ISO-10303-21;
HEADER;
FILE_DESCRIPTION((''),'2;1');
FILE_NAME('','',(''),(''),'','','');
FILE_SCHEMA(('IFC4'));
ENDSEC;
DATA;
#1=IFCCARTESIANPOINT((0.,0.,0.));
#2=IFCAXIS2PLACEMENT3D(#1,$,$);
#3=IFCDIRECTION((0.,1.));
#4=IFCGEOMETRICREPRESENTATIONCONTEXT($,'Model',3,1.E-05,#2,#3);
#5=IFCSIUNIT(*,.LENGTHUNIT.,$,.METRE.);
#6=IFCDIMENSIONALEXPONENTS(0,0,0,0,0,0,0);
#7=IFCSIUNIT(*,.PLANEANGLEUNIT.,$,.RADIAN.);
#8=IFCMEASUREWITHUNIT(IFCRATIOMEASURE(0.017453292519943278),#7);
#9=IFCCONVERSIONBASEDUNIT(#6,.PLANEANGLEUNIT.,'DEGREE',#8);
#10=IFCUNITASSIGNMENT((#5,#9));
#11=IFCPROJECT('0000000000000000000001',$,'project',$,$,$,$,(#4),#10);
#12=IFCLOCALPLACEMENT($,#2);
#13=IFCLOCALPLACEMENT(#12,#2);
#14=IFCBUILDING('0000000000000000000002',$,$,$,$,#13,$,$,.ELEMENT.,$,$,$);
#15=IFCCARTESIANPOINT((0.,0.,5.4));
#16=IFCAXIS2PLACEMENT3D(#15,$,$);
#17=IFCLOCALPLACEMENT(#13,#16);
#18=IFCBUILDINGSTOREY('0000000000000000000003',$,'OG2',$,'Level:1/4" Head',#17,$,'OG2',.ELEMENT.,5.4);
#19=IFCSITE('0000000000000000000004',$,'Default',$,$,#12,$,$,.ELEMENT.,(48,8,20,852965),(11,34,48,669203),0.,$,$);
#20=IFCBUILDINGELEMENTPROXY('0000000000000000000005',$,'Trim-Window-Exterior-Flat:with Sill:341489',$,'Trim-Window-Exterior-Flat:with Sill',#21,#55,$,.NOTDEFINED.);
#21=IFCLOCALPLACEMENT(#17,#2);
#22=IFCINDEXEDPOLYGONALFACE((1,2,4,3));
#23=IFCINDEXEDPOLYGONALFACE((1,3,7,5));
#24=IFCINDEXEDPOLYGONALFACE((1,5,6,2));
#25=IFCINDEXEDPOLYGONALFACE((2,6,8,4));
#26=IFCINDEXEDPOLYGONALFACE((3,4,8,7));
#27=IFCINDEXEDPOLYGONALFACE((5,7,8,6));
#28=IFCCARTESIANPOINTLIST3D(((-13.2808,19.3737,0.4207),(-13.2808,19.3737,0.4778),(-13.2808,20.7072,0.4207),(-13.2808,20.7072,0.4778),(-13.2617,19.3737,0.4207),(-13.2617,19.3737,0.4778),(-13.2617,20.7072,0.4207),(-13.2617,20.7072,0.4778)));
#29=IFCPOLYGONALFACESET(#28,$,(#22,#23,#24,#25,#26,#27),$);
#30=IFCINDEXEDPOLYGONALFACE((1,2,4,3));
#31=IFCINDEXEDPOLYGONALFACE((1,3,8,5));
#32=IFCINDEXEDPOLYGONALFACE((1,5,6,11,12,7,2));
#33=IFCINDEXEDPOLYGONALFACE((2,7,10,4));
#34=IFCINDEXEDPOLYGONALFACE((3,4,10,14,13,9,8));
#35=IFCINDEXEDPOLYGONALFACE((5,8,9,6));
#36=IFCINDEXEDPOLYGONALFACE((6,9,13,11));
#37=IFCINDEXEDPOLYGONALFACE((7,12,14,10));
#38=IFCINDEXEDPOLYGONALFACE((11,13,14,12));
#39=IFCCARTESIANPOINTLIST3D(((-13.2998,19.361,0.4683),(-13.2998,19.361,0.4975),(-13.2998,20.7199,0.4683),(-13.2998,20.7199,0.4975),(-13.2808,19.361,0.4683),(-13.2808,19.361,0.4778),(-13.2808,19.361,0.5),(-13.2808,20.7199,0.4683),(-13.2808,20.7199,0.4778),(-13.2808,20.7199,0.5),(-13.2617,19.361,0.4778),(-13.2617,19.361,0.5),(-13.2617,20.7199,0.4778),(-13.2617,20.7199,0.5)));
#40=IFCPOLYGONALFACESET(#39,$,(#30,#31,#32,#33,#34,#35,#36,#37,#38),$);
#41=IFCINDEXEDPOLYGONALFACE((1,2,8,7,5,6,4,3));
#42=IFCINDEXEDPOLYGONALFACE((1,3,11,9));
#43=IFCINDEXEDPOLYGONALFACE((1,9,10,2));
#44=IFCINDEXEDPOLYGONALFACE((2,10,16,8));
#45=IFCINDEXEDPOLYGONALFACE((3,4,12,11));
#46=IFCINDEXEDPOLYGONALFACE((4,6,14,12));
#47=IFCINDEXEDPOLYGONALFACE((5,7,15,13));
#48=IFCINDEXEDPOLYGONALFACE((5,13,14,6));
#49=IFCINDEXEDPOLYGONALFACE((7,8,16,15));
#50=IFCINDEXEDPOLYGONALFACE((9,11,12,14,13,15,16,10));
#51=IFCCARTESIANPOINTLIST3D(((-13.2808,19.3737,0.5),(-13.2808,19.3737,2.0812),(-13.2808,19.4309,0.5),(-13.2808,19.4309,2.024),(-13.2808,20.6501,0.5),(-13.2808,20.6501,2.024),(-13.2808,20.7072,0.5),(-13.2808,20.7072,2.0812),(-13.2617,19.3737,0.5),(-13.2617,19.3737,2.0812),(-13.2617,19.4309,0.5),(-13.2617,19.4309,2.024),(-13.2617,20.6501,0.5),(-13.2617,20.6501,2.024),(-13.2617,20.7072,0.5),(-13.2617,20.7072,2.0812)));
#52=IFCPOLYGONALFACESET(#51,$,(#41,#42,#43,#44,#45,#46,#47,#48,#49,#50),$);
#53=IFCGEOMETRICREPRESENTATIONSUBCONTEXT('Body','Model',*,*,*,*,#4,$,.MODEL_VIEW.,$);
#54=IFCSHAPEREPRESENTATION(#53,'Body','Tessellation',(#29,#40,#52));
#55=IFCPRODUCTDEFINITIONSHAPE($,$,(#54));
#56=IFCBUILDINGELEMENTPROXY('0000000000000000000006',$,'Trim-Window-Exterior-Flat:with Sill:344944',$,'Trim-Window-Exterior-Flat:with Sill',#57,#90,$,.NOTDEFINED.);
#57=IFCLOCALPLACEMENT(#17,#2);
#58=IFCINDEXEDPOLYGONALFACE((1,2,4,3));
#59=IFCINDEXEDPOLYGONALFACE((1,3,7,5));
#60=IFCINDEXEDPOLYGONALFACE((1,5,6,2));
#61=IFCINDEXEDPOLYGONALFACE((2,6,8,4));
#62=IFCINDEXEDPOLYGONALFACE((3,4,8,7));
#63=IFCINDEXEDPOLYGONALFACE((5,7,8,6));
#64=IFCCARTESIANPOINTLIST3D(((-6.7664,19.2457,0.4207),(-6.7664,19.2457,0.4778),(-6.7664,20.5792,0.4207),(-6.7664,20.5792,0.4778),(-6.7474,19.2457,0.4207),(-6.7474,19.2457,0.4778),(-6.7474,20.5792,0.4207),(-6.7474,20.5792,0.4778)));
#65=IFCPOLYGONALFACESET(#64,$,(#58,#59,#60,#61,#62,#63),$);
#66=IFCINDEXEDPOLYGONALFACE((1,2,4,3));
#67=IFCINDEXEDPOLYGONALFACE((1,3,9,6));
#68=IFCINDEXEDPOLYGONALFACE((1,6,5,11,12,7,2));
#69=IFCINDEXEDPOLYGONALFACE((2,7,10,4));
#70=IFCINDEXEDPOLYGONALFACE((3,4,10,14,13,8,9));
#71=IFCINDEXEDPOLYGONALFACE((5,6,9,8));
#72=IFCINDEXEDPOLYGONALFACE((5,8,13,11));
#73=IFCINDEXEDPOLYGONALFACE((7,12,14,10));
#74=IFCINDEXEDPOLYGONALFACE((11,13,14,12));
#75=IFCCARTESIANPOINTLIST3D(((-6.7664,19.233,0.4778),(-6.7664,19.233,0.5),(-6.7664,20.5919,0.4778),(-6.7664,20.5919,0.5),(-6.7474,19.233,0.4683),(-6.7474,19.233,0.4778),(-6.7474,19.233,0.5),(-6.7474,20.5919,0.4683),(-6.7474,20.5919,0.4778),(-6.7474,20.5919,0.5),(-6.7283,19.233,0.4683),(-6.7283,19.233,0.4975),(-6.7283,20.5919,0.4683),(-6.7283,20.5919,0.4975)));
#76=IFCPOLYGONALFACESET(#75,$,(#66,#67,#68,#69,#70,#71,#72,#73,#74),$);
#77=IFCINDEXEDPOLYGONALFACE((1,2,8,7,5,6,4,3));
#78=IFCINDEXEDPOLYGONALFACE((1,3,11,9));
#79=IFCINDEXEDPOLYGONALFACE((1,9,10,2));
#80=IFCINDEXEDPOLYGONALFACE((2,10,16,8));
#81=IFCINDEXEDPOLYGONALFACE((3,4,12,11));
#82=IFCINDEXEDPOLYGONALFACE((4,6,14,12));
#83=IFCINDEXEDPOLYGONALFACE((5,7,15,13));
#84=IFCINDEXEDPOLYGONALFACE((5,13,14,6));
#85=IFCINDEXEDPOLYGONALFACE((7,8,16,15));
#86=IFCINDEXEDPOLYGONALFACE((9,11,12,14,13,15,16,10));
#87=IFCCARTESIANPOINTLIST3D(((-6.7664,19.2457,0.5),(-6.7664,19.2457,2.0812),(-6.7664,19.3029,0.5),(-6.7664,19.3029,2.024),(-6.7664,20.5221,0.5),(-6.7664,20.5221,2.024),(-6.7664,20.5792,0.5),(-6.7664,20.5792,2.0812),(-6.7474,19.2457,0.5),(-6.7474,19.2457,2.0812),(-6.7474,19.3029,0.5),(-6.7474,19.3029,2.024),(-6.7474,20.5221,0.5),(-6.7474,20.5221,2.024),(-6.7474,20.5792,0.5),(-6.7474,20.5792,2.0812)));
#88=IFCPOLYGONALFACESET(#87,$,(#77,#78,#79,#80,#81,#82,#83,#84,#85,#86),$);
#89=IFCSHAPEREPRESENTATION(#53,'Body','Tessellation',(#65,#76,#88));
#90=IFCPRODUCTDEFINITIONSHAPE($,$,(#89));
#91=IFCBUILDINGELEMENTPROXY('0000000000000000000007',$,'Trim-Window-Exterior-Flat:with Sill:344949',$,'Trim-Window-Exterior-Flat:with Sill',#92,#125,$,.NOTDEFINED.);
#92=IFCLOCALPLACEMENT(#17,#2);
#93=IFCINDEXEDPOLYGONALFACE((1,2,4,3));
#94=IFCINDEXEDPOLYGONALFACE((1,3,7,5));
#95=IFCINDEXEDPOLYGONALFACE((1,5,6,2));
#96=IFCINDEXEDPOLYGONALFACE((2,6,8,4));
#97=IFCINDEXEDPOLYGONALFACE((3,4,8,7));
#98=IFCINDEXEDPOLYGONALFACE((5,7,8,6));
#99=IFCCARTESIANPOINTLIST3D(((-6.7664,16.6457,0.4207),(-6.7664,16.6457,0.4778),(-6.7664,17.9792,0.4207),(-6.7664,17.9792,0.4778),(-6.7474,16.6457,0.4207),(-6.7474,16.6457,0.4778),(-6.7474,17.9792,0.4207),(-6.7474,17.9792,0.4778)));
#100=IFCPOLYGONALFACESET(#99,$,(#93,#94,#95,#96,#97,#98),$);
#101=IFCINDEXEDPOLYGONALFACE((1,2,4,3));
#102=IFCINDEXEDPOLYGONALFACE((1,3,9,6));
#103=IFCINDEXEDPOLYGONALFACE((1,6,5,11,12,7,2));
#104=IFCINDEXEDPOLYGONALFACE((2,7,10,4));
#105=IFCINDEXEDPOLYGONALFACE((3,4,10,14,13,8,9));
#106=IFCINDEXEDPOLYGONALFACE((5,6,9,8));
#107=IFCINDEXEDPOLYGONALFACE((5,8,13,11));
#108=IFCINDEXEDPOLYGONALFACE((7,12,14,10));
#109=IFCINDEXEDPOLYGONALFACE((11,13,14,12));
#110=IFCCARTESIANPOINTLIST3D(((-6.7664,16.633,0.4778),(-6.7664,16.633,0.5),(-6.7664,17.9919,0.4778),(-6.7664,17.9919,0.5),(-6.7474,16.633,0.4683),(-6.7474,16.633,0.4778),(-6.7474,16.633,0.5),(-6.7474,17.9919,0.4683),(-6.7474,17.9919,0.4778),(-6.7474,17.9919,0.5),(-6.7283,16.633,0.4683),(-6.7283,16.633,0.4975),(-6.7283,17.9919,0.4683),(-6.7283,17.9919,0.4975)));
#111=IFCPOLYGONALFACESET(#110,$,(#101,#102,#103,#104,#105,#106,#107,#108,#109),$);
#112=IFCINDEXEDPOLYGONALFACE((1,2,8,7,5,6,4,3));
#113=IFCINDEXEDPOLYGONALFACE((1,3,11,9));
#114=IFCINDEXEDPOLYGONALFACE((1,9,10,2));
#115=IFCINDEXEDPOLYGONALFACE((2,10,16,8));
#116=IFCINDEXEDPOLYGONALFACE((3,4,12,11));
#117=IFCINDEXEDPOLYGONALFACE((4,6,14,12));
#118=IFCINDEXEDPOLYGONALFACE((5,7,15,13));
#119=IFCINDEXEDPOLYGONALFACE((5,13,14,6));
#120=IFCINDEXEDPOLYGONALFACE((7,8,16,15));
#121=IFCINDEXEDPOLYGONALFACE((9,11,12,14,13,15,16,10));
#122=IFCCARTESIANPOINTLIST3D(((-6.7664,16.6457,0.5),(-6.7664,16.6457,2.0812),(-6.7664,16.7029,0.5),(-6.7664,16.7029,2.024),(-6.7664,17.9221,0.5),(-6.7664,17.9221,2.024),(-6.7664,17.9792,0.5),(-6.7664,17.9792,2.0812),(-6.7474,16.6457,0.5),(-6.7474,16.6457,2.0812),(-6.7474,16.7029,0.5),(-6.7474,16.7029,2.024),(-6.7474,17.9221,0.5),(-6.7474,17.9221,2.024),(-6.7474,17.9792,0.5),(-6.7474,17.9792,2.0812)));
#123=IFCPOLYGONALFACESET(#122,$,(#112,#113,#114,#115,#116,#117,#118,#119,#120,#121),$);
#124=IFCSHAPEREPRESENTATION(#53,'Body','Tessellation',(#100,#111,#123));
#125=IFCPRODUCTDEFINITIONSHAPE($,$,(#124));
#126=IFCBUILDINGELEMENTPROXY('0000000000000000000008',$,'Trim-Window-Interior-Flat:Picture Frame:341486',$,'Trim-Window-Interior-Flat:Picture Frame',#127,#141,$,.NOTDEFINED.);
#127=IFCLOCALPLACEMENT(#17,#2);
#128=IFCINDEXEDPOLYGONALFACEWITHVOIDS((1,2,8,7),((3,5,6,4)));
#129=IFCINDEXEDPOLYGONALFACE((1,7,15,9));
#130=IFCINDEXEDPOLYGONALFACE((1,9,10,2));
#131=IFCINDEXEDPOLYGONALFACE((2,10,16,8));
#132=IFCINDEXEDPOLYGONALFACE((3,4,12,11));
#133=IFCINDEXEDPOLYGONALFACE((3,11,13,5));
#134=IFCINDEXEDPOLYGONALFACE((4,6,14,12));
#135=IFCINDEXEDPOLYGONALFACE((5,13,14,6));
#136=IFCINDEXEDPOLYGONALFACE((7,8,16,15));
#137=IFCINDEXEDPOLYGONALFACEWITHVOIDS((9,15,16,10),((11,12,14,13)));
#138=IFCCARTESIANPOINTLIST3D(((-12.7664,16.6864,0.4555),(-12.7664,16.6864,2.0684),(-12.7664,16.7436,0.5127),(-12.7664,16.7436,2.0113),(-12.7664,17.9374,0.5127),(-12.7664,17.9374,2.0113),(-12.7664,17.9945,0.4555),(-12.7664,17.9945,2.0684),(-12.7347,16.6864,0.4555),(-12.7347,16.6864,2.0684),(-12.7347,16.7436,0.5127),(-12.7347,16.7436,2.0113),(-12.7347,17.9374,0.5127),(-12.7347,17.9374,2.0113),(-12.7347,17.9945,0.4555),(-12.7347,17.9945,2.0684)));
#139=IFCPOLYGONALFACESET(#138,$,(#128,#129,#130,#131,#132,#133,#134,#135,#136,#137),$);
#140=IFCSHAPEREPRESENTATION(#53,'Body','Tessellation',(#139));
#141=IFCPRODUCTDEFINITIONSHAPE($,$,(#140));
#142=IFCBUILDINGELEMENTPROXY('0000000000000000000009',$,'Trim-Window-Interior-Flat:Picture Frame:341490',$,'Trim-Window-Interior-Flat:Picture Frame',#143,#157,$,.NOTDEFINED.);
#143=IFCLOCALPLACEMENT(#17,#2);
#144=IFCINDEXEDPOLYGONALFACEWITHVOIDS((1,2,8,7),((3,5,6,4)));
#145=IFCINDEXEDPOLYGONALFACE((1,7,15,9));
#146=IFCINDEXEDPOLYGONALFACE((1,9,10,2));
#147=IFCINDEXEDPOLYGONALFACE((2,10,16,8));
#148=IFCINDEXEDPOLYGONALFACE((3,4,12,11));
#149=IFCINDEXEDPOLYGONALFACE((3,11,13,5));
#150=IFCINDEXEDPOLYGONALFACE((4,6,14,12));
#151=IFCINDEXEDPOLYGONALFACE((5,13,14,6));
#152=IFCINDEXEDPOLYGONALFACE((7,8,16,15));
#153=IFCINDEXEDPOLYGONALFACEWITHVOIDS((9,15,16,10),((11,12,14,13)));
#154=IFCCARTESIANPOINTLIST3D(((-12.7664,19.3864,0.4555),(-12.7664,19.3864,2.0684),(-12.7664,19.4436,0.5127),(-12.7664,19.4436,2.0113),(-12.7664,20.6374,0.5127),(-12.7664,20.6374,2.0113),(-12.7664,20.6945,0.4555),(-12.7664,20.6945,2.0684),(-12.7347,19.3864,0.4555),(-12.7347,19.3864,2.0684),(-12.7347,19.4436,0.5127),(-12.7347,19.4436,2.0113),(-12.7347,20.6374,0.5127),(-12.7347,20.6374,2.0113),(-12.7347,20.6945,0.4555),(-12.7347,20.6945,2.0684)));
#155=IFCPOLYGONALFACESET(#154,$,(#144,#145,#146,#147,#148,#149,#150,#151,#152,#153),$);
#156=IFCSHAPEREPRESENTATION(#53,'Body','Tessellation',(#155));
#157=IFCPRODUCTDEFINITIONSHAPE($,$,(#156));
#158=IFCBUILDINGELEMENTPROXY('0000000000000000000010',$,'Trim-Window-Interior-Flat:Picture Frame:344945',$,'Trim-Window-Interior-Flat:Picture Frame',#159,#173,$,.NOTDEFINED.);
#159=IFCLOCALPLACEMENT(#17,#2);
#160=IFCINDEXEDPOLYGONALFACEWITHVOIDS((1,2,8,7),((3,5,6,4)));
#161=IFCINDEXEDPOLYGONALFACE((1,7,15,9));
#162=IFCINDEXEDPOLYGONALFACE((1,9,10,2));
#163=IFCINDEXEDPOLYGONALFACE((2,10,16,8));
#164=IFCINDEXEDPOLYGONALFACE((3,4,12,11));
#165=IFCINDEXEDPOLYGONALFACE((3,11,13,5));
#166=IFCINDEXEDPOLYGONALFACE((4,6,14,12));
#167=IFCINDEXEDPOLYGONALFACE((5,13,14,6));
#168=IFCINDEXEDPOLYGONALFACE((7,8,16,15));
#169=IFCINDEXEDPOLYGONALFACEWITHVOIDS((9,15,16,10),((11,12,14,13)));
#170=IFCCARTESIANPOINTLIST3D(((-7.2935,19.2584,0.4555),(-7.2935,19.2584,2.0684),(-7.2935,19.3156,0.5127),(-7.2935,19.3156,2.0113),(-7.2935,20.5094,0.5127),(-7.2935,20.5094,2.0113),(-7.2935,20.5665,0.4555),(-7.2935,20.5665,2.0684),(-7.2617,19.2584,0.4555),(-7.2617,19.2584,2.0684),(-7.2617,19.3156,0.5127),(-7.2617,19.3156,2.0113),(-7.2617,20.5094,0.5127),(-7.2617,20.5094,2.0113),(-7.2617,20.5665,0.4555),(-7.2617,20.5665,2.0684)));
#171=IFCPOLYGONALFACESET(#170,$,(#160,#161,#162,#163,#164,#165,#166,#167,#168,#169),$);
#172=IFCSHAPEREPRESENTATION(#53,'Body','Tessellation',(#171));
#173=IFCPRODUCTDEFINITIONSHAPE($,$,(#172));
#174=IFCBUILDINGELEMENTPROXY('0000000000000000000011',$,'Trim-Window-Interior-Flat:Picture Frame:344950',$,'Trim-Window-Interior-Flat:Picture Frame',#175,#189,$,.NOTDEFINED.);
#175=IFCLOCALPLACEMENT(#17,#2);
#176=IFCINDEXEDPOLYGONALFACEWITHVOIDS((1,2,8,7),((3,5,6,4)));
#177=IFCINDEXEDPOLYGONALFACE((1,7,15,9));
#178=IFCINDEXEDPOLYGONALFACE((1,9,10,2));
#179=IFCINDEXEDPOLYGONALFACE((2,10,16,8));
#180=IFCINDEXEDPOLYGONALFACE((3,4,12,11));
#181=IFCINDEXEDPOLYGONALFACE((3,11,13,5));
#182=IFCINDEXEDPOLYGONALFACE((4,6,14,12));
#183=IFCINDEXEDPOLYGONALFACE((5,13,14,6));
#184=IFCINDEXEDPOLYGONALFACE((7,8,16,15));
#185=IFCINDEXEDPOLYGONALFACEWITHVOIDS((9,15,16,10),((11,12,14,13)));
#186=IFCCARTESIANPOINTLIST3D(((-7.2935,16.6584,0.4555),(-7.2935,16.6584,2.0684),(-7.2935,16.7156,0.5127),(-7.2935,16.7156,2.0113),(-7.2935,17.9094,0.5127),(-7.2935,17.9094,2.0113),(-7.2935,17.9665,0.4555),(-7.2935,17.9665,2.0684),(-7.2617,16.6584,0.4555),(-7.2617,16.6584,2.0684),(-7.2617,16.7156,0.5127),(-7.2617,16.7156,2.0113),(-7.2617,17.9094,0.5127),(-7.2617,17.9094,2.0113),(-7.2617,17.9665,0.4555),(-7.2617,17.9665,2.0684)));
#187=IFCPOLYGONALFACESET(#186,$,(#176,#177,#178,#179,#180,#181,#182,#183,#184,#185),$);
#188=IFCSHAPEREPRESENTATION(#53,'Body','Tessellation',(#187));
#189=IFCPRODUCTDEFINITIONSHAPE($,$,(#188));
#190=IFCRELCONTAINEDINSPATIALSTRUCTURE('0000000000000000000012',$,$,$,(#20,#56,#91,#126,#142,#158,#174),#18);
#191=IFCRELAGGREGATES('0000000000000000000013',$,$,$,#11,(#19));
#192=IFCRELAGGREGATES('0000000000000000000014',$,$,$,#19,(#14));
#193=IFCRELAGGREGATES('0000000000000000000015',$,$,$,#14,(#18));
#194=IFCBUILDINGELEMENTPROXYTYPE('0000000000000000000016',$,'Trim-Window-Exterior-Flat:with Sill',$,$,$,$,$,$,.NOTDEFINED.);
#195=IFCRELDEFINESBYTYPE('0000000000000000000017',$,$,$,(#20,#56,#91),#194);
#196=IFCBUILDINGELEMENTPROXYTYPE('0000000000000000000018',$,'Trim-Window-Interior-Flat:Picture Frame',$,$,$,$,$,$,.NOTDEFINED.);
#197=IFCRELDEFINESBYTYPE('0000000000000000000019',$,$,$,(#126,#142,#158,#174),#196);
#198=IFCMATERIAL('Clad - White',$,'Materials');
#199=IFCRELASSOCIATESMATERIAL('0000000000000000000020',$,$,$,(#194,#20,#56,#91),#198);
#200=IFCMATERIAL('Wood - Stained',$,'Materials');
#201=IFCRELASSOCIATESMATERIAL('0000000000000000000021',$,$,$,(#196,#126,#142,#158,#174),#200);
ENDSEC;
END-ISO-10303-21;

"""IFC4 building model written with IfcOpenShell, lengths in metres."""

from ifc_helpers import new_model, entity, si_unit, converted_unit, direction, frame, origin, place, context, subcontext, project, spatial, indexed_curve, outline, extrude, source, transform, mapped, material, type_object, type_shapes, element, save


model = new_model("IFC4")

# Units and contexts
model_context = context("Model", 3, precision=1e-05, world=origin(), true_north=direction((0.0, 1.0)))
body_context = subcontext(model_context, "Body", "Model", "MODEL_VIEW")
ifc_project = project(units=[si_unit("LENGTHUNIT", "METRE"), converted_unit("PLANEANGLEUNIT", "DEGREE", entity("IfcRatioMeasure", 0.017453292519943278), si_unit("PLANEANGLEUNIT", "RADIAN"), dimensions=[0, 0, 0, 0, 0, 0, 0])], contexts=[model_context])

# Site, building, storey
site_placement = place(None, origin())
site = spatial("IfcSite", under=ifc_project, at=site_placement, Name="Default", CompositionType="ELEMENT", RefLatitude=(48, 8, 20, 852965), RefLongitude=(11, 34, 48, 669203), RefElevation=0.0)
building_placement = place(site_placement, origin())
building = spatial("IfcBuilding", under=site, at=building_placement, CompositionType="ELEMENT")
storey_placement = place(building_placement, frame((0.0, 0.0, 5.4)))
storey = spatial("IfcBuildingStorey", under=building, at=storey_placement, Name="OG2", ObjectType="Level:1/4\" Head", LongName="OG2", CompositionType="ELEMENT", Elevation=5.4)

# Building element proxies
ifc_material_1 = material(Name="Clad - White", Category="Materials")
ifc_material_2 = material(Name="Wood - Stained", Category="Materials")
building_element_proxy_type_1 = type_object("IfcBuildingElementProxyType", Name="Trim-Window-Exterior-Flat:with Sill", PredefinedType="NOTDEFINED", material=ifc_material_1)
shared_shape_1 = source(origin(), body_context, "Body", "SweptSolid", [
    extrude(outline(indexed_curve([(-0.6667, -0.0286), (0.6667, -0.0286), (0.6667, 0.0286), (-0.6667, 0.0286), (-0.6667, -0.0286)], self_intersect=False)), frame((0.0, -1.5748, 0.0), z_axis=(0.0, 0.0, 1.0), x_axis=(-1.0, 0.0, 0.0)), (0.0, 0.0, 1.0), 0.019),
    extrude(outline(indexed_curve([(-0.019, -0.016), (0.0, -0.016), (0.0, -0.0064), (0.019, -0.0064), (0.019, 0.0158), (0.0, 0.0158), (-0.019, 0.0133), (-0.019, -0.016)], self_intersect=False)), frame((-0.6794, -1.5398, 0.019), z_axis=(1.0, 0.0, 0.0), x_axis=(0.0, 0.0, -1.0)), (0.0, 0.0, 1.0), 1.3589),
    extrude(outline(indexed_curve([(-0.8049, -0.6667), (0.7763, -0.6667), (0.7763, -0.6096), (-0.7477, -0.6096), (-0.7477, 0.6096), (0.7763, 0.6096), (0.7763, 0.6667), (-0.8049, 0.6667), (-0.8049, -0.6667)], self_intersect=False)), frame((0.0, -0.7477, 0.0), z_axis=(0.0, 0.0, 1.0), x_axis=(0.0, -1.0, 0.0)), (0.0, 0.0, 1.0), 0.019),
])
type_shapes(building_element_proxy_type_1, [shared_shape_1])
for number, where, z_axis, x_axis, name in (
    (1, (-13.2617, 20.0405, 2.024), (-1.0, 0.0, 0.0), (0.0, -1.0, 0.0), "Trim-Window-Exterior-Flat:with Sill:341489"),
    (2, (-6.7664, 19.9125, 2.024), (1.0, 0.0, 0.0), (0.0, 1.0, 0.0), "Trim-Window-Exterior-Flat:with Sill:344944"),
    (3, (-6.7664, 17.3125, 2.024), (1.0, 0.0, 0.0), (0.0, 1.0, 0.0), "Trim-Window-Exterior-Flat:with Sill:344949"),
):
    element("IfcBuildingElementProxy", number, at=place(storey_placement, frame(where, z_axis=z_axis, x_axis=x_axis)), inside=storey, type_object=building_element_proxy_type_1, material=ifc_material_1, Name=name, ObjectType="Trim-Window-Exterior-Flat:with Sill", PredefinedType="NOTDEFINED", context=body_context, shape_type="MappedRepresentation", body=[
        mapped(shared_shape_1, transform((0.0, 0.0, 0.0), scale=1.0)),
    ])
building_element_proxy_type_2 = type_object("IfcBuildingElementProxyType", Name="Trim-Window-Interior-Flat:Picture Frame", PredefinedType="NOTDEFINED", material=ifc_material_2)
shared_shape_2 = source(origin(), body_context, "Body", "SweptSolid", [
    extrude(outline(indexed_curve([(-0.654, -0.8064), (0.654, -0.8064), (0.654, 0.8064), (-0.654, 0.8064), (-0.654, -0.8064)], self_intersect=False), holes=[indexed_curve([(-0.5969, -0.7493), (-0.5969, 0.7493), (0.5969, 0.7493), (0.5969, -0.7493), (-0.5969, -0.7493)], self_intersect=False)]), frame((0.0, -0.762, 0.0), z_axis=(0.0, 0.0, 1.0), x_axis=(-1.0, 0.0, 0.0)), (0.0, 0.0, 1.0), 0.0317),
])
type_shapes(building_element_proxy_type_2, [shared_shape_2])
for number, where, z_axis, x_axis, name in (
    (4, (-12.7664, 17.3405, 2.024), (1.0, 0.0, 0.0), (0.0, 1.0, 0.0), "Trim-Window-Interior-Flat:Picture Frame:341486"),
    (5, (-12.7664, 20.0405, 2.024), (1.0, 0.0, 0.0), (0.0, 1.0, 0.0), "Trim-Window-Interior-Flat:Picture Frame:341490"),
    (6, (-7.2617, 19.9125, 2.024), (-1.0, 0.0, 0.0), (0.0, -1.0, 0.0), "Trim-Window-Interior-Flat:Picture Frame:344945"),
    (7, (-7.2617, 17.3125, 2.024), (-1.0, 0.0, 0.0), (0.0, -1.0, 0.0), "Trim-Window-Interior-Flat:Picture Frame:344950"),
):
    element("IfcBuildingElementProxy", number, at=place(storey_placement, frame(where, z_axis=z_axis, x_axis=x_axis)), inside=storey, type_object=building_element_proxy_type_2, material=ifc_material_2, Name=name, ObjectType="Trim-Window-Interior-Flat:Picture Frame", PredefinedType="NOTDEFINED", context=body_context, shape_type="MappedRepresentation", body=[
        mapped(shared_shape_2, transform((0.0, 0.0, 0.0), scale=1.0)),
    ])

save(model, "model.ifc")
